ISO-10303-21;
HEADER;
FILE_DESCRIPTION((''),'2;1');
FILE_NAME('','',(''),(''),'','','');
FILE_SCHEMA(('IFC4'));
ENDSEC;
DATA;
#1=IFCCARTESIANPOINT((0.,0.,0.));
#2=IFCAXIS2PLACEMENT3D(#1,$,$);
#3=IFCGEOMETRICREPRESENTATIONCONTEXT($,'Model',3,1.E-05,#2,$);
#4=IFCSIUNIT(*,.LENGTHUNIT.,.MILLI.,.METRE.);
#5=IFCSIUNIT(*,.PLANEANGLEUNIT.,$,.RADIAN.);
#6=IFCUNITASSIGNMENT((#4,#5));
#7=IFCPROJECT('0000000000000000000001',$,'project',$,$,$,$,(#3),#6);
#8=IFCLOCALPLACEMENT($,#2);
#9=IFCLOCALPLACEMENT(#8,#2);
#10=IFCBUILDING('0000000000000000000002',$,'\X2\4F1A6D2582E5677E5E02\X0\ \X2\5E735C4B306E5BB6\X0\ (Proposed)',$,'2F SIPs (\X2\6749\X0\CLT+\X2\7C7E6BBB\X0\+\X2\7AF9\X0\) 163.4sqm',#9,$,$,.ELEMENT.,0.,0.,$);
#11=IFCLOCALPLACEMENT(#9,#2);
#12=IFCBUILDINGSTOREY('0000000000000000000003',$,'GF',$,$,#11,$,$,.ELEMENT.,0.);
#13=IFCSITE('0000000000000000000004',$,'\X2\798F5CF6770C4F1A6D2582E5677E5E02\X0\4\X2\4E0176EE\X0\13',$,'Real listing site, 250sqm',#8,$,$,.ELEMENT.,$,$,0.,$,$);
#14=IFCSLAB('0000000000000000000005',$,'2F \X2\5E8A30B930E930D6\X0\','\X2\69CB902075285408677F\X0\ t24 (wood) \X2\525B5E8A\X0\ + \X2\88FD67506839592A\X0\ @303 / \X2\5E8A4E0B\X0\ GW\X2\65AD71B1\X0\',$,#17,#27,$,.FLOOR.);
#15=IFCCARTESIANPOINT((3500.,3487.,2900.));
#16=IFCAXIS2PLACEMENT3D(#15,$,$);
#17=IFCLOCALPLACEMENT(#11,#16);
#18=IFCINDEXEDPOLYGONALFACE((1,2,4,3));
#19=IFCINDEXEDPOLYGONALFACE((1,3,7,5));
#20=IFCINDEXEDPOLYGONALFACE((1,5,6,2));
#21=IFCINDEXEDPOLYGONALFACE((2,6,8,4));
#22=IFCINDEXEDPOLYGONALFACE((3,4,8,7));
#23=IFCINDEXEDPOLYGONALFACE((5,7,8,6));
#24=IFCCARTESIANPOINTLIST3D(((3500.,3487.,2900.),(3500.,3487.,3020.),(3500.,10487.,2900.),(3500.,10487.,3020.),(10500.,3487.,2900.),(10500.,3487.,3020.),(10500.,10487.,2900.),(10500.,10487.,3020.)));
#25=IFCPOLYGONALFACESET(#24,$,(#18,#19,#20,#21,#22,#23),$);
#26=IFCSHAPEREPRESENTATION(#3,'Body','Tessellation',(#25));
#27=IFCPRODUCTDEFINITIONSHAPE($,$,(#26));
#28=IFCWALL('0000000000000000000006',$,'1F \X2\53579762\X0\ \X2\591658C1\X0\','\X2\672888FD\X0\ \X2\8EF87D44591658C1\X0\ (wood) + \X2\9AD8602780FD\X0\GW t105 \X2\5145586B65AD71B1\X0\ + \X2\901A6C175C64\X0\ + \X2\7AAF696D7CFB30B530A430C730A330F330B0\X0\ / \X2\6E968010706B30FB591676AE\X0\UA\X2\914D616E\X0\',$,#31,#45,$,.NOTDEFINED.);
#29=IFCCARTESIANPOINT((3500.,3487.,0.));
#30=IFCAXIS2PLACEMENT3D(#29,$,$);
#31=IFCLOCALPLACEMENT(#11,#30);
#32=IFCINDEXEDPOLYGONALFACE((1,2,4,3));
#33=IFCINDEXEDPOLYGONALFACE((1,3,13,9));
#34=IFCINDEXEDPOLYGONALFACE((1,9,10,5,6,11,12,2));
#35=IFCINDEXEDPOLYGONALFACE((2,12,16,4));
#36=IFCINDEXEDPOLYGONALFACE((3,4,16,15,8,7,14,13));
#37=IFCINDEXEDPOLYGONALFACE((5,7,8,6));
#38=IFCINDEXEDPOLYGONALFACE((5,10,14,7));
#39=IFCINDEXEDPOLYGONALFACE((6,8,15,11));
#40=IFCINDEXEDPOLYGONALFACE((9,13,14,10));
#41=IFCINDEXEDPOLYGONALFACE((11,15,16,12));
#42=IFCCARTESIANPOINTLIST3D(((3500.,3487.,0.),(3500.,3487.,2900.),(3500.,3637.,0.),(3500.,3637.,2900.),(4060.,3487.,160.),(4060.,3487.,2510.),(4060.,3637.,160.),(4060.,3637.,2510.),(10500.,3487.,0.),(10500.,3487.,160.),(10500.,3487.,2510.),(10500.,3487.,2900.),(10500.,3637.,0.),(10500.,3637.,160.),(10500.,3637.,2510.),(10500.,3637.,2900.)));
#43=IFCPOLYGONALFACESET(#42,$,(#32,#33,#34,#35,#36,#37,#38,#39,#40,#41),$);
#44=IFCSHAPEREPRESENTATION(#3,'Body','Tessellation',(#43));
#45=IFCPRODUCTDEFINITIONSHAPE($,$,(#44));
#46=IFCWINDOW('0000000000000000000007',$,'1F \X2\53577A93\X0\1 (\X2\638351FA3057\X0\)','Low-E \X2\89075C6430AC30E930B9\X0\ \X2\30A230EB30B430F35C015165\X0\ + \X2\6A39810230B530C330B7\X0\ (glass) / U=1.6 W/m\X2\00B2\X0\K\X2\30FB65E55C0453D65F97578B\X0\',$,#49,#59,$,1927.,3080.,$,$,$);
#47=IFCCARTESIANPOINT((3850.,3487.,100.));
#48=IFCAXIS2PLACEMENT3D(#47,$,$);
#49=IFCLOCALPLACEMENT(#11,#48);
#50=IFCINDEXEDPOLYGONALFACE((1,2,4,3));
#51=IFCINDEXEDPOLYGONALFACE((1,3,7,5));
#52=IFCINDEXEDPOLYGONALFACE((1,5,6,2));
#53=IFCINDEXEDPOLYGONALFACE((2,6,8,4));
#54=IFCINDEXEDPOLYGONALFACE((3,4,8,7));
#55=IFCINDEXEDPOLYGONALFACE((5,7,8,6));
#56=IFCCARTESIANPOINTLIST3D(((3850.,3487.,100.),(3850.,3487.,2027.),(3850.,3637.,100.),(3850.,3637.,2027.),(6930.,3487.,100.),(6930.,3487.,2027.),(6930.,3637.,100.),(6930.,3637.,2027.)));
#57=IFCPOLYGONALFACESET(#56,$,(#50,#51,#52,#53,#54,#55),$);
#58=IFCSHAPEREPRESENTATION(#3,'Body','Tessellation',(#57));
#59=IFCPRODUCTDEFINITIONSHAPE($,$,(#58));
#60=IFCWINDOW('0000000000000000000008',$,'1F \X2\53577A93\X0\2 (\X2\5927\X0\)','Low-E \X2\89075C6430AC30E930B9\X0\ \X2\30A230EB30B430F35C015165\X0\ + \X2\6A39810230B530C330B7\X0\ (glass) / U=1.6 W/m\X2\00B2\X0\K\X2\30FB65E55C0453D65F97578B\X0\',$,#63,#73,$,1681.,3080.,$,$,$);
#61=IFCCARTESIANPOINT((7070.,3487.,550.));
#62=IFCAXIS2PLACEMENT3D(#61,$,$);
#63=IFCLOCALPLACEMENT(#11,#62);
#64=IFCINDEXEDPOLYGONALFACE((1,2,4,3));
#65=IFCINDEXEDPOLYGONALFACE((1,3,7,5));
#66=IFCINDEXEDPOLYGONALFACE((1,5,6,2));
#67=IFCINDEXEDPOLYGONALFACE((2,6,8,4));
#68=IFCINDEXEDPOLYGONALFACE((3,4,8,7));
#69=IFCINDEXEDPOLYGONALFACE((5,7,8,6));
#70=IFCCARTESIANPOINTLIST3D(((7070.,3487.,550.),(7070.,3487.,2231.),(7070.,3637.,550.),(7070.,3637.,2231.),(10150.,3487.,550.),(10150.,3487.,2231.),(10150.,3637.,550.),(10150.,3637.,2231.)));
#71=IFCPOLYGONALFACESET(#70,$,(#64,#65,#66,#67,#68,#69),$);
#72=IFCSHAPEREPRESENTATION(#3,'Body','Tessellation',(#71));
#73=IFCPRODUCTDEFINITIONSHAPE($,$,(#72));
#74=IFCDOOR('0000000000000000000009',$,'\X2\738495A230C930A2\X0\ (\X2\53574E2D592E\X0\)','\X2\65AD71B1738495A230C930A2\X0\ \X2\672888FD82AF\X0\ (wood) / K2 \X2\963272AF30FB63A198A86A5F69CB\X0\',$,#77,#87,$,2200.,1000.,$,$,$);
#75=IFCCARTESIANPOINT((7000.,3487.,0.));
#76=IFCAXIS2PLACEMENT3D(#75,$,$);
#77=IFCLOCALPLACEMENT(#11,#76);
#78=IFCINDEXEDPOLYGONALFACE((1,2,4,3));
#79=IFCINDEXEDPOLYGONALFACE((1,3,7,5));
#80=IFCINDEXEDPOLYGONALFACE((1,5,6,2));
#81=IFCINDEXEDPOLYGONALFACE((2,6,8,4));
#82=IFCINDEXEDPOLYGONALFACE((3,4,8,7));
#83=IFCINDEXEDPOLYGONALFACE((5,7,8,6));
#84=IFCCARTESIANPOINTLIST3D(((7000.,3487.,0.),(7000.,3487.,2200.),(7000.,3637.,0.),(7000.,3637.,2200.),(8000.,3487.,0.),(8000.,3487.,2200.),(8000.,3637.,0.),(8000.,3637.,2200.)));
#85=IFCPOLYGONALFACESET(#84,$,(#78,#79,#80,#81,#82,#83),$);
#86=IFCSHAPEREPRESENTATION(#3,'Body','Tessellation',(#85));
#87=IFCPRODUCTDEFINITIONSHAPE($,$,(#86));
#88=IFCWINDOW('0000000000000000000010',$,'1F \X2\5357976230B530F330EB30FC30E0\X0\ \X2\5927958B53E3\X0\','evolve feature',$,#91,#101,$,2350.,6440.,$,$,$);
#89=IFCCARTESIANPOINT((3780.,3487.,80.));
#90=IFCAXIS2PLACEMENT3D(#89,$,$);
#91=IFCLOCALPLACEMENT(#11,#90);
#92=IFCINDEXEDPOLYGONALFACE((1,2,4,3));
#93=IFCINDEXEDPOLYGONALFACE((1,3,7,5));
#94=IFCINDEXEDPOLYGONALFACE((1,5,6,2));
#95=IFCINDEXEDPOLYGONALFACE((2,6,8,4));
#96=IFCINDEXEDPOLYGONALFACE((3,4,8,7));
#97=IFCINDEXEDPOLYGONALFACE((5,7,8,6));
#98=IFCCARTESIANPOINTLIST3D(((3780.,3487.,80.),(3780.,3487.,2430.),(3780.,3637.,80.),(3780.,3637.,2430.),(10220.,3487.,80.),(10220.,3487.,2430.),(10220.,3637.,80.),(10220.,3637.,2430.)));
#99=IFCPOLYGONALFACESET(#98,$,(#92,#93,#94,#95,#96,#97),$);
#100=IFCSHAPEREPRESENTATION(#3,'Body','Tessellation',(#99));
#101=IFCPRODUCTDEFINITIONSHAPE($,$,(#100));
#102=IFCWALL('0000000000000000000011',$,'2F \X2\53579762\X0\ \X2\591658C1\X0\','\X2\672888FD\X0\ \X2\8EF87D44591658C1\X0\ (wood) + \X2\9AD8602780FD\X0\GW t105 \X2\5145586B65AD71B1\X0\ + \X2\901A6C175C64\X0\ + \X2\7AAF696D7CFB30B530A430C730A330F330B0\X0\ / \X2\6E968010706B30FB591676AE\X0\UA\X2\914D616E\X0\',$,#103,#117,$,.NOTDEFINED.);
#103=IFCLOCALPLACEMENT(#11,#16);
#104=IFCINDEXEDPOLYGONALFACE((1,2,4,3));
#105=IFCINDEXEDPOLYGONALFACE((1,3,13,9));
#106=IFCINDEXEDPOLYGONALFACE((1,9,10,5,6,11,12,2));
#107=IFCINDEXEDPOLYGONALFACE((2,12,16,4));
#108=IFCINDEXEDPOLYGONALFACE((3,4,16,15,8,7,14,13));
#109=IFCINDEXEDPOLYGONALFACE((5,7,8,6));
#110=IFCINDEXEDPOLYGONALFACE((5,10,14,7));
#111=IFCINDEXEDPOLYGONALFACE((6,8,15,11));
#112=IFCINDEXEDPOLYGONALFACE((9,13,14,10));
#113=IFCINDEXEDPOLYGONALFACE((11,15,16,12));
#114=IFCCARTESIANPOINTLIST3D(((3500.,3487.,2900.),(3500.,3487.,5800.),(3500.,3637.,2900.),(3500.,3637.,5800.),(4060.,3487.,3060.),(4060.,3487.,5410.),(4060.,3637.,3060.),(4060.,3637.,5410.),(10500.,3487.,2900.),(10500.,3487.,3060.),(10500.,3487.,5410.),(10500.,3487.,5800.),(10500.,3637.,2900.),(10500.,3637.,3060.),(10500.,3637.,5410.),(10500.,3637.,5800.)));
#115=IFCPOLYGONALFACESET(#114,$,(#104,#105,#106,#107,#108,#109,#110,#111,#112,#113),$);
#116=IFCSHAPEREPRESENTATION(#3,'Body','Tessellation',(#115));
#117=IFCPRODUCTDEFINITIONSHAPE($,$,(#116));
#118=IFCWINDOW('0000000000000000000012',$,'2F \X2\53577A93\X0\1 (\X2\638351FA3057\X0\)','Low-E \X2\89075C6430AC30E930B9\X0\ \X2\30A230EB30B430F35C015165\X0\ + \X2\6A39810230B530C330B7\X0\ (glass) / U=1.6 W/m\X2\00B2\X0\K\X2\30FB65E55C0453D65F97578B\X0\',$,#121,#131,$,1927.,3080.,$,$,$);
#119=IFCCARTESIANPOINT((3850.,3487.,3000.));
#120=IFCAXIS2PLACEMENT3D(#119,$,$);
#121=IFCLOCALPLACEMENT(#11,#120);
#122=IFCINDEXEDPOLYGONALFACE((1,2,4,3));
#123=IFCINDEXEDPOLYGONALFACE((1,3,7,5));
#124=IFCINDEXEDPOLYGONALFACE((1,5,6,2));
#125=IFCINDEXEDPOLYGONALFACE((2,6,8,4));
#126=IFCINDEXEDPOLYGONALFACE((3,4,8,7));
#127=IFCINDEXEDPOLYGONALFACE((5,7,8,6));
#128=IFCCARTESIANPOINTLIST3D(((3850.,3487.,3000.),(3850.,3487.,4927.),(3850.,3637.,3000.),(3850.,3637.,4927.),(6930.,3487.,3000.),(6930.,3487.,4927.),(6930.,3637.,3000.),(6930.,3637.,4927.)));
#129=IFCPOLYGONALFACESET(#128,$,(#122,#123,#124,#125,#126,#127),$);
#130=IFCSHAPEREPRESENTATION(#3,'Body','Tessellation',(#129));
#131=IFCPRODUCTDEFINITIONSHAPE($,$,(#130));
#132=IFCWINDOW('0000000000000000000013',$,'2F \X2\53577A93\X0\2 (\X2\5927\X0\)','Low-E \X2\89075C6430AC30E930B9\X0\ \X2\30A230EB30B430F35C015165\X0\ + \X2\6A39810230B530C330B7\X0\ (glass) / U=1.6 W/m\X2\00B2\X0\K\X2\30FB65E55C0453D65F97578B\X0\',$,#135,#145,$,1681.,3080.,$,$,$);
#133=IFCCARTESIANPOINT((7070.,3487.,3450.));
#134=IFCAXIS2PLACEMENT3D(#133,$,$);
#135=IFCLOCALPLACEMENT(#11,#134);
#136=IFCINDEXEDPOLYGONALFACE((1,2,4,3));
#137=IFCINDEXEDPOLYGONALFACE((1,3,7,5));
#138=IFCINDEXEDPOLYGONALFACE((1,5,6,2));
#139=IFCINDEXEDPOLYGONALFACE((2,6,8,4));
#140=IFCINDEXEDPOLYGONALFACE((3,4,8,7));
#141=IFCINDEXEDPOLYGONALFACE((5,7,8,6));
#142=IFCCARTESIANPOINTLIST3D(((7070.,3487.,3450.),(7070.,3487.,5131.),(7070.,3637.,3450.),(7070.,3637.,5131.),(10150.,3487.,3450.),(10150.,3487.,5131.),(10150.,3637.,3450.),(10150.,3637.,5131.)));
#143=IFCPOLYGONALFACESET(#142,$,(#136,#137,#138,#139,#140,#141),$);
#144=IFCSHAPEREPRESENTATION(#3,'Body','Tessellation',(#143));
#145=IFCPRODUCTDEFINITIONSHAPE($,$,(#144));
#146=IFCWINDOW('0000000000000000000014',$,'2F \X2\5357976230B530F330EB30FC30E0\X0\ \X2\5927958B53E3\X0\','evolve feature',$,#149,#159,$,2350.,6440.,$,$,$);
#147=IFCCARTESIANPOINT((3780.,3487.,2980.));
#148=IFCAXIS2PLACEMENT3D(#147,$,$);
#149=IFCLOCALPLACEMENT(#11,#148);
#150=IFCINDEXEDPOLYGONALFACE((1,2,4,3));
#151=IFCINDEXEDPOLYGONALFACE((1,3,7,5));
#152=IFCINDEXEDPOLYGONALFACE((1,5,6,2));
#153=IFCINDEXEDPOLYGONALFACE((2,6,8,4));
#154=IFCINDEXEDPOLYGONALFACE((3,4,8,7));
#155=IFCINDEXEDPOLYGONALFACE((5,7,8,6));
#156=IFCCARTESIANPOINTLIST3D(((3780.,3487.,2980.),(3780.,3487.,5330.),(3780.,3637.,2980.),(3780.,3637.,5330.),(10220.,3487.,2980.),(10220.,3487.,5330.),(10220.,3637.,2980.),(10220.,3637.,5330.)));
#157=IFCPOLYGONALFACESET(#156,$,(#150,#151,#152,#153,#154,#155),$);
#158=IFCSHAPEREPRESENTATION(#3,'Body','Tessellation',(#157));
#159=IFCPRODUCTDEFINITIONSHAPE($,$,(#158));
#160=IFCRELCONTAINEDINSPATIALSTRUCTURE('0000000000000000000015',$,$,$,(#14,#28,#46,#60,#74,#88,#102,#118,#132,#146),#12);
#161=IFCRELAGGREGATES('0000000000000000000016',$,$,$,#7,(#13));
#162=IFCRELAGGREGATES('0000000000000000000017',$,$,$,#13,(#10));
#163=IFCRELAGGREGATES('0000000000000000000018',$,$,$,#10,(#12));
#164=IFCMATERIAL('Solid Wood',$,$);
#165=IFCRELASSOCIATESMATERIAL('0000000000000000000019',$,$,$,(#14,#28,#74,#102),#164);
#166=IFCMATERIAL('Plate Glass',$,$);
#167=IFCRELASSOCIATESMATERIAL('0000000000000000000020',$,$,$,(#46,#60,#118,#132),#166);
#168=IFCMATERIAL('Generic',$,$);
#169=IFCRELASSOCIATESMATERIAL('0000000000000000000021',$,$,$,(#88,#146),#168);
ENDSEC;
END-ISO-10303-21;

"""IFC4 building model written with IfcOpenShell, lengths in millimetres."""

from ifc_helpers import new_model, si_unit, frame, frame_2d, origin, place, context, project, spatial, rectangle, extrude, material, element, fill, save


model = new_model("IFC4")

# Units and contexts
model_context = context("Model", 3, precision=1e-05, world=origin())
ifc_project = project(units=[si_unit("LENGTHUNIT", "METRE", prefix="MILLI"), si_unit("PLANEANGLEUNIT", "RADIAN")], contexts=[model_context])

# Site, building, storey
site_placement = place(None, origin())
site = spatial("IfcSite", under=ifc_project, at=site_placement, Name="福島県会津若松市4丁目13", ObjectType="Real listing site, 250sqm", CompositionType="ELEMENT", RefElevation=0.0)
building_placement = place(site_placement, origin())
building = spatial("IfcBuilding", under=site, at=building_placement, Name="会津若松市 平屋の家 (Proposed)", ObjectType="2F SIPs (杉CLT+籾殻+竹) 163.4sqm", CompositionType="ELEMENT", ElevationOfRefHeight=0.0, ElevationOfTerrain=0.0)
storey_placement = place(building_placement, origin())
storey = spatial("IfcBuildingStorey", under=building, at=storey_placement, Name="GF", CompositionType="ELEMENT", Elevation=0.0)

# Slab
ifc_material_1 = material(Name="Solid Wood")
slab_1_placement = place(storey_placement, frame((3500.0, 3487.0, 2900.0)))
element("IfcSlab", 1, at=slab_1_placement, inside=storey, material=ifc_material_1, Name="2F 床スラブ", Description="構造用合板 t24 (wood) 剛床 + 製材根太 @303 / 床下 GW断熱", PredefinedType="FLOOR", context=model_context, shape_type="SweptSolid", body=[
    extrude(rectangle(XDim=7000.0, YDim=7000.0, at=frame_2d((3500.0, 3500.0))), frame((3500.0, 3487.0, 2900.0)), (0.0, 0.0, 1.0), 120.0),
])
ifc_material_2 = material(Name="Generic")

# Wall, openings, windows, door
wall_1_placement = place(storey_placement, frame((3500.0, 3487.0, 0.0)))
wall_1 = element("IfcWall", 2, at=wall_1_placement, inside=storey, material=ifc_material_1, Name="1F 南面 外壁", Description="木製 軸組外壁 (wood) + 高性能GW t105 充填断熱 + 通気層 + 窯業系サイディング / 準耐火・外皮UA配慮", PredefinedType="NOTDEFINED", context=model_context, shape_type="SweptSolid", body=[
    extrude(rectangle(XDim=7000.0, YDim=150.0, at=frame_2d((3500.0, 75.0))), frame((3500.0, 3487.0, 0.0)), (0.0, 0.0, 1.0), 2900.0),
])
opening_1_placement = place(storey_placement, frame((3850.0, 3487.0, 100.0)))
opening_1 = element("IfcOpeningElement", 3, at=opening_1_placement, cuts=wall_1, PredefinedType="NOTDEFINED", context=model_context, shape_type="SweptSolid", body=[
    extrude(rectangle(XDim=3080.0, YDim=150.0, at=frame_2d((1540.0, 75.0))), frame((3850.0, 3487.0, 100.0)), (0.0, 0.0, 1.0), 1927.0),
])
opening_2_placement = place(storey_placement, frame((7070.0, 3487.0, 550.0)))
opening_2 = element("IfcOpeningElement", 4, at=opening_2_placement, cuts=wall_1, PredefinedType="NOTDEFINED", context=model_context, shape_type="SweptSolid", body=[
    extrude(rectangle(XDim=3080.0, YDim=150.0, at=frame_2d((1540.0, 75.0))), frame((7070.0, 3487.0, 550.0)), (0.0, 0.0, 1.0), 1681.0),
])
opening_3_placement = place(storey_placement, frame((7000.0, 3487.0, 0.0)))
opening_3 = element("IfcOpeningElement", 5, at=opening_3_placement, cuts=wall_1, PredefinedType="NOTDEFINED", context=model_context, shape_type="SweptSolid", body=[
    extrude(rectangle(XDim=1000.0, YDim=150.0, at=frame_2d((500.0, 75.0))), frame((7000.0, 3487.0, 0.0)), (0.0, 0.0, 1.0), 2200.0),
])
opening_4_placement = place(storey_placement, frame((3780.0, 3487.0, 80.0)))
opening_4 = element("IfcOpeningElement", 6, at=opening_4_placement, cuts=wall_1, PredefinedType="NOTDEFINED", context=model_context, shape_type="SweptSolid", body=[
    extrude(rectangle(XDim=6440.0, YDim=150.0, at=frame_2d((3220.0, 75.0))), frame((3780.0, 3487.0, 80.0)), (0.0, 0.0, 1.0), 2350.0),
])
ifc_material_3 = material(Name="Plate Glass")
window_1_placement = place(storey_placement, frame((3850.0, 3487.0, 100.0)))
window_1 = element("IfcWindow", 7, at=window_1_placement, inside=storey, material=ifc_material_3, Name="1F 南窓1 (掃出し)", Description="Low-E 複層ガラス アルゴン封入 + 樹脂サッシ (glass) / U=1.6 W/m²K・日射取得型", OverallHeight=1927.0, OverallWidth=3080.0, context=model_context, shape_type="SweptSolid", body=[
    extrude(rectangle(XDim=3080.0, YDim=150.0, at=frame_2d((1540.0, 75.0))), frame((3850.0, 3487.0, 100.0)), (0.0, 0.0, 1.0), 1927.0),
])
fill(opening_1, window_1)
window_2_placement = place(storey_placement, frame((7070.0, 3487.0, 550.0)))
window_2 = element("IfcWindow", 8, at=window_2_placement, inside=storey, material=ifc_material_3, Name="1F 南窓2 (大)", Description="Low-E 複層ガラス アルゴン封入 + 樹脂サッシ (glass) / U=1.6 W/m²K・日射取得型", OverallHeight=1681.0, OverallWidth=3080.0, context=model_context, shape_type="SweptSolid", body=[
    extrude(rectangle(XDim=3080.0, YDim=150.0, at=frame_2d((1540.0, 75.0))), frame((7070.0, 3487.0, 550.0)), (0.0, 0.0, 1.0), 1681.0),
])
fill(opening_2, window_2)
door_placement = place(storey_placement, frame((7000.0, 3487.0, 0.0)))
door = element("IfcDoor", 9, at=door_placement, inside=storey, material=ifc_material_1, Name="玄関ドア (南中央)", Description="断熱玄関ドア 木製芯 (wood) / K2 防犯・採風機構", OverallHeight=2200.0, OverallWidth=1000.0, context=model_context, shape_type="SweptSolid", body=[
    extrude(rectangle(XDim=1000.0, YDim=150.0, at=frame_2d((500.0, 75.0))), frame((7000.0, 3487.0, 0.0)), (0.0, 0.0, 1.0), 2200.0),
])
fill(opening_3, door)
window_3_placement = place(storey_placement, frame((3780.0, 3487.0, 80.0)))
window_3 = element("IfcWindow", 10, at=window_3_placement, inside=storey, material=ifc_material_2, Name="1F 南面サンルーム 大開口", Description="evolve feature", OverallHeight=2350.0, OverallWidth=6440.0, context=model_context, shape_type="SweptSolid", body=[
    extrude(rectangle(XDim=6440.0, YDim=150.0, at=frame_2d((3220.0, 75.0))), frame((3780.0, 3487.0, 80.0)), (0.0, 0.0, 1.0), 2350.0),
])
fill(opening_4, window_3)

# Wall, openings, windows
wall_2_placement = place(storey_placement, frame((3500.0, 3487.0, 2900.0)))
wall_2 = element("IfcWall", 11, at=wall_2_placement, inside=storey, material=ifc_material_1, Name="2F 南面 外壁", Description="木製 軸組外壁 (wood) + 高性能GW t105 充填断熱 + 通気層 + 窯業系サイディング / 準耐火・外皮UA配慮", PredefinedType="NOTDEFINED", context=model_context, shape_type="SweptSolid", body=[
    extrude(rectangle(XDim=7000.0, YDim=150.0, at=frame_2d((3500.0, 75.0))), frame((3500.0, 3487.0, 2900.0)), (0.0, 0.0, 1.0), 2900.0),
])
opening_5_placement = place(storey_placement, frame((3850.0, 3487.0, 3000.0)))
opening_5 = element("IfcOpeningElement", 12, at=opening_5_placement, cuts=wall_2, PredefinedType="NOTDEFINED", context=model_context, shape_type="SweptSolid", body=[
    extrude(rectangle(XDim=3080.0, YDim=150.0, at=frame_2d((1540.0, 75.0))), frame((3850.0, 3487.0, 3000.0)), (0.0, 0.0, 1.0), 1927.0),
])
opening_6_placement = place(storey_placement, frame((7070.0, 3487.0, 3450.0)))
opening_6 = element("IfcOpeningElement", 13, at=opening_6_placement, cuts=wall_2, PredefinedType="NOTDEFINED", context=model_context, shape_type="SweptSolid", body=[
    extrude(rectangle(XDim=3080.0, YDim=150.0, at=frame_2d((1540.0, 75.0))), frame((7070.0, 3487.0, 3450.0)), (0.0, 0.0, 1.0), 1681.0),
])
opening_7_placement = place(storey_placement, frame((3780.0, 3487.0, 2980.0)))
opening_7 = element("IfcOpeningElement", 14, at=opening_7_placement, cuts=wall_2, PredefinedType="NOTDEFINED", context=model_context, shape_type="SweptSolid", body=[
    extrude(rectangle(XDim=6440.0, YDim=150.0, at=frame_2d((3220.0, 75.0))), frame((3780.0, 3487.0, 2980.0)), (0.0, 0.0, 1.0), 2350.0),
])
window_4_placement = place(storey_placement, frame((3850.0, 3487.0, 3000.0)))
window_4 = element("IfcWindow", 15, at=window_4_placement, inside=storey, material=ifc_material_3, Name="2F 南窓1 (掃出し)", Description="Low-E 複層ガラス アルゴン封入 + 樹脂サッシ (glass) / U=1.6 W/m²K・日射取得型", OverallHeight=1927.0, OverallWidth=3080.0, context=model_context, shape_type="SweptSolid", body=[
    extrude(rectangle(XDim=3080.0, YDim=150.0, at=frame_2d((1540.0, 75.0))), frame((3850.0, 3487.0, 3000.0)), (0.0, 0.0, 1.0), 1927.0),
])
fill(opening_5, window_4)
window_5_placement = place(storey_placement, frame((7070.0, 3487.0, 3450.0)))
window_5 = element("IfcWindow", 16, at=window_5_placement, inside=storey, material=ifc_material_3, Name="2F 南窓2 (大)", Description="Low-E 複層ガラス アルゴン封入 + 樹脂サッシ (glass) / U=1.6 W/m²K・日射取得型", OverallHeight=1681.0, OverallWidth=3080.0, context=model_context, shape_type="SweptSolid", body=[
    extrude(rectangle(XDim=3080.0, YDim=150.0, at=frame_2d((1540.0, 75.0))), frame((7070.0, 3487.0, 3450.0)), (0.0, 0.0, 1.0), 1681.0),
])
fill(opening_6, window_5)
window_6_placement = place(storey_placement, frame((3780.0, 3487.0, 2980.0)))
window_6 = element("IfcWindow", 17, at=window_6_placement, inside=storey, material=ifc_material_2, Name="2F 南面サンルーム 大開口", Description="evolve feature", OverallHeight=2350.0, OverallWidth=6440.0, context=model_context, shape_type="SweptSolid", body=[
    extrude(rectangle(XDim=6440.0, YDim=150.0, at=frame_2d((3220.0, 75.0))), frame((3780.0, 3487.0, 2980.0)), (0.0, 0.0, 1.0), 2350.0),
])
fill(opening_7, window_6)

save(model, "model.ifc")
